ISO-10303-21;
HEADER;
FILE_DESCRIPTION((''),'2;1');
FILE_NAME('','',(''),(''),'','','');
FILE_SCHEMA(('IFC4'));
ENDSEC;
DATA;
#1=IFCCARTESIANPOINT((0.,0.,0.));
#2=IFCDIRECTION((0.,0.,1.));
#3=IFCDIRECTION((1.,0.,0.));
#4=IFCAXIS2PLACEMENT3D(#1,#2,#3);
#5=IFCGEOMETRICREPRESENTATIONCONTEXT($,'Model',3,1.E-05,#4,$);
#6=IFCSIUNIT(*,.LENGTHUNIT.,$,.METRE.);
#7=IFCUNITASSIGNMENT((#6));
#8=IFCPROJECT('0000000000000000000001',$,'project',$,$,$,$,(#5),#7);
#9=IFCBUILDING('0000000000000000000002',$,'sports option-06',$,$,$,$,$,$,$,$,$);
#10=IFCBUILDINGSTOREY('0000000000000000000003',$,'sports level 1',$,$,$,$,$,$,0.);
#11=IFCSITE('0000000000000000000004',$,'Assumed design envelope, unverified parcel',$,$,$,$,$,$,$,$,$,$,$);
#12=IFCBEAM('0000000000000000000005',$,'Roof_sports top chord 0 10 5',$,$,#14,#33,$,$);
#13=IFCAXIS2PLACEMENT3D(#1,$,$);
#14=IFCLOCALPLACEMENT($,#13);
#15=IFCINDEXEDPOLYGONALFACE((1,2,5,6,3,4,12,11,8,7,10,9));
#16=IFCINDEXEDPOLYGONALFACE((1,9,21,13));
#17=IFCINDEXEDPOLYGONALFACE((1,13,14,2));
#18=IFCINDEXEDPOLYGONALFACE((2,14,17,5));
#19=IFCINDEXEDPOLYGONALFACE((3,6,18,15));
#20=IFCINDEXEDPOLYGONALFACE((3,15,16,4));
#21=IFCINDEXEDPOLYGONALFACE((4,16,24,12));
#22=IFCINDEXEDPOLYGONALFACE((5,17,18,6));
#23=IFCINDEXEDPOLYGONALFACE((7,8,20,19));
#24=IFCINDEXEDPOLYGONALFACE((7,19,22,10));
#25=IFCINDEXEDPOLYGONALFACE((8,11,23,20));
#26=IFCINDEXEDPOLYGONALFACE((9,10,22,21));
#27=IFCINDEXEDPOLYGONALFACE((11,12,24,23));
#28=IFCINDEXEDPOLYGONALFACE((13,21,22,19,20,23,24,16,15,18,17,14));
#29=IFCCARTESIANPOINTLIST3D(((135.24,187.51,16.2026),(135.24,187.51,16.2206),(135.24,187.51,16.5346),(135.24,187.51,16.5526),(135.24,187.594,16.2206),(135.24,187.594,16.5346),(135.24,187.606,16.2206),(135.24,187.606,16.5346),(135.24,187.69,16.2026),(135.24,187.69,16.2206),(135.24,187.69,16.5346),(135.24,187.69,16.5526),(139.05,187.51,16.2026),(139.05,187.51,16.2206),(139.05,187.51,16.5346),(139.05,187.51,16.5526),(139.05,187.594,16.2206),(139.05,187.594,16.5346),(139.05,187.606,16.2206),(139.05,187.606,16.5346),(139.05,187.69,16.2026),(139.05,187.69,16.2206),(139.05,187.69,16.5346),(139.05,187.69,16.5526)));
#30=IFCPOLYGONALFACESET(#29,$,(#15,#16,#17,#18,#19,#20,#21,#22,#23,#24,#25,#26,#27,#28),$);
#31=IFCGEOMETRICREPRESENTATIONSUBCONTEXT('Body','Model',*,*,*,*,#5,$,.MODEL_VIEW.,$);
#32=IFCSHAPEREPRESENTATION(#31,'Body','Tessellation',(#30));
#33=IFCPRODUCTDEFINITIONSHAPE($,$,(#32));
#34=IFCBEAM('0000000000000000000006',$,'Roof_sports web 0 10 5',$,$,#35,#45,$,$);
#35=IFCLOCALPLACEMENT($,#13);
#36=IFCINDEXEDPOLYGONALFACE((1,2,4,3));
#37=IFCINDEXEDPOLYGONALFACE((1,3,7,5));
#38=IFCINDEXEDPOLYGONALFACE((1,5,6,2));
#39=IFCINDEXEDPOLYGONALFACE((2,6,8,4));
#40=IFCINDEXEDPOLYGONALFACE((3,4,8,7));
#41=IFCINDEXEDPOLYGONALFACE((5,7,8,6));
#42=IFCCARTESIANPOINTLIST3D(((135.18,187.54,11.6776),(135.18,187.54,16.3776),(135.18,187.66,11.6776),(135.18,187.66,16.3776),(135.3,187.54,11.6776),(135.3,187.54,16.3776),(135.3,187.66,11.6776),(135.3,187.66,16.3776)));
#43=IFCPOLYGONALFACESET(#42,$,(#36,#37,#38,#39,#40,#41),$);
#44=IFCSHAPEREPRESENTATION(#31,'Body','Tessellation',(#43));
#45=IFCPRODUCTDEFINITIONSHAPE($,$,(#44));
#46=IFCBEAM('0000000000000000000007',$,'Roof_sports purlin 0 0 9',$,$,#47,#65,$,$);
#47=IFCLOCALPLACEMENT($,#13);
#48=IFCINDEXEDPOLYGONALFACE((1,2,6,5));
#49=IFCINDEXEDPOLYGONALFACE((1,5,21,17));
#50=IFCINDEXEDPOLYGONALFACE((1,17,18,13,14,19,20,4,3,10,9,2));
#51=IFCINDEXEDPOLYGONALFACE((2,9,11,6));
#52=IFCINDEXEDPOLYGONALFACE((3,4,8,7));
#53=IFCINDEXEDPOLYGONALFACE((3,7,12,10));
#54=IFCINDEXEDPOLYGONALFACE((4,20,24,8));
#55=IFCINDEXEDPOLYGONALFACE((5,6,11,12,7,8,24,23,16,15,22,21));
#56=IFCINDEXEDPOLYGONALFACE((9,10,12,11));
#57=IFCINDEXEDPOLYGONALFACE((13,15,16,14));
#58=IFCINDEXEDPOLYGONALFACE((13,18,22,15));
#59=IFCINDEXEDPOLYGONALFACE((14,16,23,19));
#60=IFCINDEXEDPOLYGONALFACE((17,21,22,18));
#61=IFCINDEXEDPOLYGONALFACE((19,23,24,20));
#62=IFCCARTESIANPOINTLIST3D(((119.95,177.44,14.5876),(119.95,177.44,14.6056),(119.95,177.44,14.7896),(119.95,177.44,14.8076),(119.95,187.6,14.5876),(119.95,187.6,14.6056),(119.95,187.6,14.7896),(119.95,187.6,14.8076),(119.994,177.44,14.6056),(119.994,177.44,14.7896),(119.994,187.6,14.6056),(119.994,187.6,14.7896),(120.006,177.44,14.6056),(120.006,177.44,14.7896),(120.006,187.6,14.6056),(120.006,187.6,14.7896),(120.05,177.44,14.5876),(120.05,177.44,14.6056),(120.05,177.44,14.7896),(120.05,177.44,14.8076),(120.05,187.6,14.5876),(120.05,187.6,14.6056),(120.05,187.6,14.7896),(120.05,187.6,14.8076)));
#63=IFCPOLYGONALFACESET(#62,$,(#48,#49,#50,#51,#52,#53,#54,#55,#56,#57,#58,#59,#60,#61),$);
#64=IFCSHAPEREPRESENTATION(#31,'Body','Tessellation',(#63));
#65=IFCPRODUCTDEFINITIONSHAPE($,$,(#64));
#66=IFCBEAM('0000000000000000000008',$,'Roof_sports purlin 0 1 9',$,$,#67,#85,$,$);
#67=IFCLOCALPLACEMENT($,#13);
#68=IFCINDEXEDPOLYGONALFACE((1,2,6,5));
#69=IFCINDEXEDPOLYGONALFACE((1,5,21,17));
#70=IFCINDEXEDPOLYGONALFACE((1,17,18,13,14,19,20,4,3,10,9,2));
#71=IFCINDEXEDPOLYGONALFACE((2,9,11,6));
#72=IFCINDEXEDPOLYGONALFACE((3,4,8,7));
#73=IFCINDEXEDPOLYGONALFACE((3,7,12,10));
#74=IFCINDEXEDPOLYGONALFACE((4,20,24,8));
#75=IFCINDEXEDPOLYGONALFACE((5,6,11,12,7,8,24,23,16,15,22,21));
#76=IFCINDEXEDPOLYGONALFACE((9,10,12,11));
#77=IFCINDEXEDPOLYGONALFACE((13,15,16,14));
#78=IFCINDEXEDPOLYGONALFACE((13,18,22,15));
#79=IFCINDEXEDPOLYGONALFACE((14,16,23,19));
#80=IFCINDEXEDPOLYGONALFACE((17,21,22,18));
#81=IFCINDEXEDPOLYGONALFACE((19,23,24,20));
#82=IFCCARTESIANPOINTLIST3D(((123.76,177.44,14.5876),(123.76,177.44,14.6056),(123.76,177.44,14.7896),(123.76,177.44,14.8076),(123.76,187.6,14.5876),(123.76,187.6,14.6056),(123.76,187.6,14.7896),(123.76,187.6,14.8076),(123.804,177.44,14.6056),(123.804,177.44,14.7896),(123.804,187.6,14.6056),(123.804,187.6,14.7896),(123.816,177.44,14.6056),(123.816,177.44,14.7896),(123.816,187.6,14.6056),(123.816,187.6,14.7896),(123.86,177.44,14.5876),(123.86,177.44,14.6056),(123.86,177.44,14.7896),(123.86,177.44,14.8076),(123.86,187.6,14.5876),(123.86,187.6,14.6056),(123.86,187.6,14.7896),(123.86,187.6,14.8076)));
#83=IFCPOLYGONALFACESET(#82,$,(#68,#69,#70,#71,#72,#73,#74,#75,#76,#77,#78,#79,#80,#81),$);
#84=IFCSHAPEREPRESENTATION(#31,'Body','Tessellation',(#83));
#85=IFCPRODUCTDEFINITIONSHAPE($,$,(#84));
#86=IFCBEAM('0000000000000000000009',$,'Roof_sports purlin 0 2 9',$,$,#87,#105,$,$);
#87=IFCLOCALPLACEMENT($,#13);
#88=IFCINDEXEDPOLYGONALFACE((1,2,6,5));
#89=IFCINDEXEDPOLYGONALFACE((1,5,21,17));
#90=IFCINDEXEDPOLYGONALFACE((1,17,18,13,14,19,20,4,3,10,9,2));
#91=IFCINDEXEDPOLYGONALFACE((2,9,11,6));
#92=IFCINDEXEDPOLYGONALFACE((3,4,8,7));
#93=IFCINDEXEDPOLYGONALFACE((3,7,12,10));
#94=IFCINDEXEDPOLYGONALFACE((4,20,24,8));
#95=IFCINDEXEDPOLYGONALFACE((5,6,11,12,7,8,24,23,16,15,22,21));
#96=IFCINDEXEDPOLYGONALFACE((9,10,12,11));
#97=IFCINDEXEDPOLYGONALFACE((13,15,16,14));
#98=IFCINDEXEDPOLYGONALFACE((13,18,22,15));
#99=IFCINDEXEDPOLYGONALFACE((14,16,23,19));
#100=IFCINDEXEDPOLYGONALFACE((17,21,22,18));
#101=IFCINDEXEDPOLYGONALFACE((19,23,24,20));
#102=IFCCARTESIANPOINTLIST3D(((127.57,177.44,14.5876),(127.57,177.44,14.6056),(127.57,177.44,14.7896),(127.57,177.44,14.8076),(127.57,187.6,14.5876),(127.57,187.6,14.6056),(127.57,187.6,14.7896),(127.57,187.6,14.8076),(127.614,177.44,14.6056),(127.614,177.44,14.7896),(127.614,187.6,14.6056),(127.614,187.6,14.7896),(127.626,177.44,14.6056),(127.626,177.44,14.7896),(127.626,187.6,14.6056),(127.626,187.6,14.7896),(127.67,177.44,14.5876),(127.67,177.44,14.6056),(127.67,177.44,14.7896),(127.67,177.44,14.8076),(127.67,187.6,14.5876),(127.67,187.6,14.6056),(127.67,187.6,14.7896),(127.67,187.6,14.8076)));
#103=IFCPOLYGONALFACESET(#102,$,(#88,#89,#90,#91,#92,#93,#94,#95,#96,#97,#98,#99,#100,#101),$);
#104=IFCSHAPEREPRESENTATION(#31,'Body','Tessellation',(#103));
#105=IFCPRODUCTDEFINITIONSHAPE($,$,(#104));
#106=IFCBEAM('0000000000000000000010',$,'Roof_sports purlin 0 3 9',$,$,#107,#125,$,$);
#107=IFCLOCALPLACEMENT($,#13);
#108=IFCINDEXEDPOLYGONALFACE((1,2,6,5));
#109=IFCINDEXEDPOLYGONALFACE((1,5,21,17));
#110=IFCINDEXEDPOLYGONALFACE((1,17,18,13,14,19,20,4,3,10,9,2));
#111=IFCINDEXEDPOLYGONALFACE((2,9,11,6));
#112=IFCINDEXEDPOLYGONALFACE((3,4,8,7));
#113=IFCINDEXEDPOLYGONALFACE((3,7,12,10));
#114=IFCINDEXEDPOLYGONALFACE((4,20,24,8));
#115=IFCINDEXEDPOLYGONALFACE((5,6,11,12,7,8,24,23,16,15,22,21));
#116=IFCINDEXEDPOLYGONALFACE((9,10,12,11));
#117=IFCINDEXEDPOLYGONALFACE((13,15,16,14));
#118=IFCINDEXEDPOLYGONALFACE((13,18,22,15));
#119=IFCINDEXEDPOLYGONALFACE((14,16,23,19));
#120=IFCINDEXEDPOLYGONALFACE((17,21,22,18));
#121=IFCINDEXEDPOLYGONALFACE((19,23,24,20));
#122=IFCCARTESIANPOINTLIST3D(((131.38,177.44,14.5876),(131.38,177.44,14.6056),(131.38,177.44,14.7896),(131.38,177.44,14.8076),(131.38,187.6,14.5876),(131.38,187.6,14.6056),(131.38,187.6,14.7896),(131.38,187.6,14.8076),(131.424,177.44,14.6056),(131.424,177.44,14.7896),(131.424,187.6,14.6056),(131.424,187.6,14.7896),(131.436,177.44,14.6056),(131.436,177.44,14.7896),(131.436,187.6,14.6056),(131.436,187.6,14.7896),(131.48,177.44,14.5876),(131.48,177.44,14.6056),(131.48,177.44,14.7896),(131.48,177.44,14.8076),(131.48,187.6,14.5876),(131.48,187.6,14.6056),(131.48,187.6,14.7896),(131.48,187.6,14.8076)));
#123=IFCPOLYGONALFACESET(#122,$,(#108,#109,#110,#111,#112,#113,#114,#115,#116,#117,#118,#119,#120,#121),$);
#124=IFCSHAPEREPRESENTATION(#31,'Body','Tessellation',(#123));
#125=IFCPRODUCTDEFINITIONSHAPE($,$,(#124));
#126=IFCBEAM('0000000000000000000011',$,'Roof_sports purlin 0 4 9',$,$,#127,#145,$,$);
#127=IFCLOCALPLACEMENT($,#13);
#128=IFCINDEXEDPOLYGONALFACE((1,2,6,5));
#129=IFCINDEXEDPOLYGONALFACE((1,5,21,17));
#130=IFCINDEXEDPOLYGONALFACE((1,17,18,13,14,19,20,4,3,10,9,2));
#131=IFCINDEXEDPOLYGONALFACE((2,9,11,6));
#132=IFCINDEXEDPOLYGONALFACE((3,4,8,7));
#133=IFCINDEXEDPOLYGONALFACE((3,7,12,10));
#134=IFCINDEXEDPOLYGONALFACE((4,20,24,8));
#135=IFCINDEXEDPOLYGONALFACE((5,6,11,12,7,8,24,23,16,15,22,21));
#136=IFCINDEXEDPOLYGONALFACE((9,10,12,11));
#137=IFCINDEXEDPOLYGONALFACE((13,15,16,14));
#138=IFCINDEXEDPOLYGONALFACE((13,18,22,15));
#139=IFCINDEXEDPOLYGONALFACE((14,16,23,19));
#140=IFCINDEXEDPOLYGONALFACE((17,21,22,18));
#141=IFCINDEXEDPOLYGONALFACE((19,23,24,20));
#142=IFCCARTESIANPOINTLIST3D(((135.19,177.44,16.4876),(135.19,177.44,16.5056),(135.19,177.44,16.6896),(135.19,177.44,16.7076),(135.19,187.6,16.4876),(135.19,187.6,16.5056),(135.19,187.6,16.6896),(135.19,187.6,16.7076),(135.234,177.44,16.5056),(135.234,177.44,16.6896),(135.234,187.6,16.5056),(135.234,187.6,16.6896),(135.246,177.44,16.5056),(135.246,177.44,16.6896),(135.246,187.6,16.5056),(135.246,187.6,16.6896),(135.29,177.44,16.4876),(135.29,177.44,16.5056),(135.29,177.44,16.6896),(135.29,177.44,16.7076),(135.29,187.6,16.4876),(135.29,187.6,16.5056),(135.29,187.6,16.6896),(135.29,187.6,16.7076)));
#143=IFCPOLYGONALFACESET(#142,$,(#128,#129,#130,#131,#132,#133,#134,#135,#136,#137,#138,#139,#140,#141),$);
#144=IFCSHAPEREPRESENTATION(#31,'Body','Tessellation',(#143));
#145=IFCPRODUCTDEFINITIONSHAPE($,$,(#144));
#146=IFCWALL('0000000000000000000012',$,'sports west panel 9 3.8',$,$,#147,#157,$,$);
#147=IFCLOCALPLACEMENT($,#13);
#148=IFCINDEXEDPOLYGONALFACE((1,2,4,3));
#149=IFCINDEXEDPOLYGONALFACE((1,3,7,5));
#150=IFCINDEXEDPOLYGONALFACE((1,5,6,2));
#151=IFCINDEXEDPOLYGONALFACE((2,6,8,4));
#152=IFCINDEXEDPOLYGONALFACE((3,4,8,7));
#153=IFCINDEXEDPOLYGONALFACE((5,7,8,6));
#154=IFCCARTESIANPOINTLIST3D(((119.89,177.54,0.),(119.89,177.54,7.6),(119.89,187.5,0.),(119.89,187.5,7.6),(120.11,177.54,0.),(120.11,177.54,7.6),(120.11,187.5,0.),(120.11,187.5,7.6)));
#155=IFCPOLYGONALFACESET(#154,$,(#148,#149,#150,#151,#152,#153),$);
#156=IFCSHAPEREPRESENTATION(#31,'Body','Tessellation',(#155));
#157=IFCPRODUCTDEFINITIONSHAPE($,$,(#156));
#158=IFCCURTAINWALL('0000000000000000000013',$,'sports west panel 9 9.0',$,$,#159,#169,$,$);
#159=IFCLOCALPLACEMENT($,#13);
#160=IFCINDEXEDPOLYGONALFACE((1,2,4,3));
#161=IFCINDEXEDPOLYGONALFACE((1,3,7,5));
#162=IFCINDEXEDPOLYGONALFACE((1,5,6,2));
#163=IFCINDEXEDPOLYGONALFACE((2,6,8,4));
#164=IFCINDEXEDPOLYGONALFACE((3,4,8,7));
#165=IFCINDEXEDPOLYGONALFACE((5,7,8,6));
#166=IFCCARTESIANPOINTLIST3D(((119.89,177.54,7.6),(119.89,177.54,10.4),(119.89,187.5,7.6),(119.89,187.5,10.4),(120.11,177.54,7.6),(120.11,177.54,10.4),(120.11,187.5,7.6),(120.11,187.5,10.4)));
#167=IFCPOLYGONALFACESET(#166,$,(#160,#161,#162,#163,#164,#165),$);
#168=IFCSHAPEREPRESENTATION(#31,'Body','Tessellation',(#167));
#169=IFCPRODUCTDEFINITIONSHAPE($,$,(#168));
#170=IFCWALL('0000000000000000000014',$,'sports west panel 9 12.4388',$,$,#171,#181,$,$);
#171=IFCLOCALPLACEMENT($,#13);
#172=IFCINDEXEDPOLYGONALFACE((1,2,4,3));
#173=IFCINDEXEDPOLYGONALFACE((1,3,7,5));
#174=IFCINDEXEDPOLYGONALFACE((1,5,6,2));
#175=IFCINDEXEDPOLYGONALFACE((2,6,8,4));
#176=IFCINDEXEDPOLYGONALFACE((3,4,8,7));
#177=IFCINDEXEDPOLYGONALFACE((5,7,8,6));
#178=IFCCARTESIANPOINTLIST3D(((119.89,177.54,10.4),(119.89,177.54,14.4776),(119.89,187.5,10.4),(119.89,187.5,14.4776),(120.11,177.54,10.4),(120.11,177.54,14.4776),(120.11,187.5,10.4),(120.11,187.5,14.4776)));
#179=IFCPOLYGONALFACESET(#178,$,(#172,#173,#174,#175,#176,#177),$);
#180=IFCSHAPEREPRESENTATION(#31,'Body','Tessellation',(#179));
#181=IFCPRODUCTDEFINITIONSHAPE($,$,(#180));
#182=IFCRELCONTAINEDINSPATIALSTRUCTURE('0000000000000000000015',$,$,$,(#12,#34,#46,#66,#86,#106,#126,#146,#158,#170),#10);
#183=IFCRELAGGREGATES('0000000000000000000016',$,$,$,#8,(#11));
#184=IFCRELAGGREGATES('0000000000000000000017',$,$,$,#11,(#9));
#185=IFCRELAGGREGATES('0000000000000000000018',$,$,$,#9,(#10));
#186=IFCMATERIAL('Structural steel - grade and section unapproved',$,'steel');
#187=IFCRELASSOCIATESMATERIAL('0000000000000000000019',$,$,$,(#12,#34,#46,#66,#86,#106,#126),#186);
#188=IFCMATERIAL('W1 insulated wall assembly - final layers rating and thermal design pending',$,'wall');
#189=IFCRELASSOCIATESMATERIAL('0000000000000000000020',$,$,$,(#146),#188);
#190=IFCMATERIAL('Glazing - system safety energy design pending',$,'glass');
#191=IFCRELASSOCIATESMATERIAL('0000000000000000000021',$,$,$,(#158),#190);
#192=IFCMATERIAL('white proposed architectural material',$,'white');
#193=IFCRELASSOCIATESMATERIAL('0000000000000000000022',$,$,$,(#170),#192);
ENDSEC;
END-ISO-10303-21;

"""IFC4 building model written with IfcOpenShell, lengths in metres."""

from ifc_helpers import new_model, si_unit, frame, origin_with_axes, place, context, subcontext, project, spatial, rectangle, i_section, extrude, material, element, save


model = new_model("IFC4")

# Units and contexts
model_context = context("Model", 3, precision=1e-05, world=origin_with_axes())
body_context = subcontext(model_context, "Body", "Model", "MODEL_VIEW")
ifc_project = project(units=[si_unit("LENGTHUNIT", "METRE")], contexts=[model_context])

# Site, building, storey
site = spatial("IfcSite", under=ifc_project, Name="Assumed design envelope, unverified parcel")
building = spatial("IfcBuilding", under=site, Name="sports option-06")
storey = spatial("IfcBuildingStorey", under=building, Name="sports level 1", Elevation=0.0)

# Shared definitions
ifc_material_1 = material(Name="Structural steel - grade and section unapproved", Category="steel")

# Beams
beam_1_placement = place(None, frame((135.24, 187.6, 16.3776), z_axis=(1.0, 0.0, 0.0), x_axis=(0.0, 1.0, 0.0)))
element("IfcBeam", 1, at=beam_1_placement, inside=storey, material=ifc_material_1, Name="Roof_sports top chord 0 10 5", context=body_context, shape_type="SweptSolid", body=[
    extrude(i_section(OverallWidth=0.18, OverallDepth=0.35, WebThickness=0.012, FlangeThickness=0.018, FilletRadius=0.0), origin_with_axes(), (0.0, 0.0, 1.0), 3.81),
])
beam_2_placement = place(None, frame((135.24, 187.6, 11.6776), z_axis=(0.0, 0.0, 1.0), x_axis=(-1.0, 0.0, 0.0)))
element("IfcBeam", 2, at=beam_2_placement, inside=storey, material=ifc_material_1, Name="Roof_sports web 0 10 5", context=body_context, shape_type="SweptSolid", body=[
    extrude(rectangle(XDim=0.12, YDim=0.12), origin_with_axes(), (0.0, 0.0, 1.0), 4.7),
])
for number, where, z_axis, x_axis, name in (
    (3, (120.0, 177.44, 14.6976), (0.0, 1.0, 0.0), (-1.0, 0.0, 0.0), "Roof_sports purlin 0 0 9"),
    (4, (123.81, 177.44, 14.6976), (0.0, 1.0, 0.0), (-1.0, 0.0, 0.0), "Roof_sports purlin 0 1 9"),
    (5, (127.62, 177.44, 14.6976), (0.0, 1.0, 0.0), (-1.0, 0.0, 0.0), "Roof_sports purlin 0 2 9"),
    (6, (131.43, 177.44, 14.6976), (0.0, 1.0, 0.0), (-1.0, 0.0, 0.0), "Roof_sports purlin 0 3 9"),
    (7, (135.24, 177.44, 16.5976), (0.0, 1.0, 0.0), (-1.0, 0.0, 0.0), "Roof_sports purlin 0 4 9"),
):
    element("IfcBeam", number, at=place(None, frame(where, z_axis=z_axis, x_axis=x_axis)), inside=storey, material=ifc_material_1, Name=name, context=body_context, shape_type="SweptSolid", body=[
        extrude(i_section(OverallWidth=0.1, OverallDepth=0.22, WebThickness=0.012, FlangeThickness=0.018, FilletRadius=0.0), origin_with_axes(), (0.0, 0.0, 1.0), 10.16),
    ])

# Wall
ifc_material_2 = material(Name="W1 insulated wall assembly - final layers rating and thermal design pending", Category="wall")
wall_1_placement = place(None, frame((120.0, 182.52, 0.0), z_axis=(0.0, 0.0, 1.0), x_axis=(1.0, 0.0, 0.0)))
element("IfcWall", 8, at=wall_1_placement, inside=storey, material=ifc_material_2, Name="sports west panel 9 3.8", context=body_context, shape_type="SweptSolid", body=[
    extrude(rectangle(XDim=0.22, YDim=9.96), origin_with_axes(), (0.0, 0.0, 1.0), 7.6),
])

# Curtain wall
ifc_material_3 = material(Name="Glazing - system safety energy design pending", Category="glass")
curtain_wall_placement = place(None, frame((120.0, 182.52, 7.6), z_axis=(0.0, 0.0, 1.0), x_axis=(1.0, 0.0, 0.0)))
element("IfcCurtainWall", 9, at=curtain_wall_placement, inside=storey, material=ifc_material_3, Name="sports west panel 9 9.0", context=body_context, shape_type="SweptSolid", body=[
    extrude(rectangle(XDim=0.22, YDim=9.96), origin_with_axes(), (0.0, 0.0, 1.0), 2.8),
])

# Wall
ifc_material_4 = material(Name="white proposed architectural material", Category="white")
wall_2_placement = place(None, frame((120.0, 182.52, 10.4), z_axis=(0.0, 0.0, 1.0), x_axis=(1.0, 0.0, 0.0)))
element("IfcWall", 10, at=wall_2_placement, inside=storey, material=ifc_material_4, Name="sports west panel 9 12.4388", context=body_context, shape_type="SweptSolid", body=[
    extrude(rectangle(XDim=0.22, YDim=9.96), origin_with_axes(), (0.0, 0.0, 1.0), 4.0776),
])

save(model, "model.ifc")
